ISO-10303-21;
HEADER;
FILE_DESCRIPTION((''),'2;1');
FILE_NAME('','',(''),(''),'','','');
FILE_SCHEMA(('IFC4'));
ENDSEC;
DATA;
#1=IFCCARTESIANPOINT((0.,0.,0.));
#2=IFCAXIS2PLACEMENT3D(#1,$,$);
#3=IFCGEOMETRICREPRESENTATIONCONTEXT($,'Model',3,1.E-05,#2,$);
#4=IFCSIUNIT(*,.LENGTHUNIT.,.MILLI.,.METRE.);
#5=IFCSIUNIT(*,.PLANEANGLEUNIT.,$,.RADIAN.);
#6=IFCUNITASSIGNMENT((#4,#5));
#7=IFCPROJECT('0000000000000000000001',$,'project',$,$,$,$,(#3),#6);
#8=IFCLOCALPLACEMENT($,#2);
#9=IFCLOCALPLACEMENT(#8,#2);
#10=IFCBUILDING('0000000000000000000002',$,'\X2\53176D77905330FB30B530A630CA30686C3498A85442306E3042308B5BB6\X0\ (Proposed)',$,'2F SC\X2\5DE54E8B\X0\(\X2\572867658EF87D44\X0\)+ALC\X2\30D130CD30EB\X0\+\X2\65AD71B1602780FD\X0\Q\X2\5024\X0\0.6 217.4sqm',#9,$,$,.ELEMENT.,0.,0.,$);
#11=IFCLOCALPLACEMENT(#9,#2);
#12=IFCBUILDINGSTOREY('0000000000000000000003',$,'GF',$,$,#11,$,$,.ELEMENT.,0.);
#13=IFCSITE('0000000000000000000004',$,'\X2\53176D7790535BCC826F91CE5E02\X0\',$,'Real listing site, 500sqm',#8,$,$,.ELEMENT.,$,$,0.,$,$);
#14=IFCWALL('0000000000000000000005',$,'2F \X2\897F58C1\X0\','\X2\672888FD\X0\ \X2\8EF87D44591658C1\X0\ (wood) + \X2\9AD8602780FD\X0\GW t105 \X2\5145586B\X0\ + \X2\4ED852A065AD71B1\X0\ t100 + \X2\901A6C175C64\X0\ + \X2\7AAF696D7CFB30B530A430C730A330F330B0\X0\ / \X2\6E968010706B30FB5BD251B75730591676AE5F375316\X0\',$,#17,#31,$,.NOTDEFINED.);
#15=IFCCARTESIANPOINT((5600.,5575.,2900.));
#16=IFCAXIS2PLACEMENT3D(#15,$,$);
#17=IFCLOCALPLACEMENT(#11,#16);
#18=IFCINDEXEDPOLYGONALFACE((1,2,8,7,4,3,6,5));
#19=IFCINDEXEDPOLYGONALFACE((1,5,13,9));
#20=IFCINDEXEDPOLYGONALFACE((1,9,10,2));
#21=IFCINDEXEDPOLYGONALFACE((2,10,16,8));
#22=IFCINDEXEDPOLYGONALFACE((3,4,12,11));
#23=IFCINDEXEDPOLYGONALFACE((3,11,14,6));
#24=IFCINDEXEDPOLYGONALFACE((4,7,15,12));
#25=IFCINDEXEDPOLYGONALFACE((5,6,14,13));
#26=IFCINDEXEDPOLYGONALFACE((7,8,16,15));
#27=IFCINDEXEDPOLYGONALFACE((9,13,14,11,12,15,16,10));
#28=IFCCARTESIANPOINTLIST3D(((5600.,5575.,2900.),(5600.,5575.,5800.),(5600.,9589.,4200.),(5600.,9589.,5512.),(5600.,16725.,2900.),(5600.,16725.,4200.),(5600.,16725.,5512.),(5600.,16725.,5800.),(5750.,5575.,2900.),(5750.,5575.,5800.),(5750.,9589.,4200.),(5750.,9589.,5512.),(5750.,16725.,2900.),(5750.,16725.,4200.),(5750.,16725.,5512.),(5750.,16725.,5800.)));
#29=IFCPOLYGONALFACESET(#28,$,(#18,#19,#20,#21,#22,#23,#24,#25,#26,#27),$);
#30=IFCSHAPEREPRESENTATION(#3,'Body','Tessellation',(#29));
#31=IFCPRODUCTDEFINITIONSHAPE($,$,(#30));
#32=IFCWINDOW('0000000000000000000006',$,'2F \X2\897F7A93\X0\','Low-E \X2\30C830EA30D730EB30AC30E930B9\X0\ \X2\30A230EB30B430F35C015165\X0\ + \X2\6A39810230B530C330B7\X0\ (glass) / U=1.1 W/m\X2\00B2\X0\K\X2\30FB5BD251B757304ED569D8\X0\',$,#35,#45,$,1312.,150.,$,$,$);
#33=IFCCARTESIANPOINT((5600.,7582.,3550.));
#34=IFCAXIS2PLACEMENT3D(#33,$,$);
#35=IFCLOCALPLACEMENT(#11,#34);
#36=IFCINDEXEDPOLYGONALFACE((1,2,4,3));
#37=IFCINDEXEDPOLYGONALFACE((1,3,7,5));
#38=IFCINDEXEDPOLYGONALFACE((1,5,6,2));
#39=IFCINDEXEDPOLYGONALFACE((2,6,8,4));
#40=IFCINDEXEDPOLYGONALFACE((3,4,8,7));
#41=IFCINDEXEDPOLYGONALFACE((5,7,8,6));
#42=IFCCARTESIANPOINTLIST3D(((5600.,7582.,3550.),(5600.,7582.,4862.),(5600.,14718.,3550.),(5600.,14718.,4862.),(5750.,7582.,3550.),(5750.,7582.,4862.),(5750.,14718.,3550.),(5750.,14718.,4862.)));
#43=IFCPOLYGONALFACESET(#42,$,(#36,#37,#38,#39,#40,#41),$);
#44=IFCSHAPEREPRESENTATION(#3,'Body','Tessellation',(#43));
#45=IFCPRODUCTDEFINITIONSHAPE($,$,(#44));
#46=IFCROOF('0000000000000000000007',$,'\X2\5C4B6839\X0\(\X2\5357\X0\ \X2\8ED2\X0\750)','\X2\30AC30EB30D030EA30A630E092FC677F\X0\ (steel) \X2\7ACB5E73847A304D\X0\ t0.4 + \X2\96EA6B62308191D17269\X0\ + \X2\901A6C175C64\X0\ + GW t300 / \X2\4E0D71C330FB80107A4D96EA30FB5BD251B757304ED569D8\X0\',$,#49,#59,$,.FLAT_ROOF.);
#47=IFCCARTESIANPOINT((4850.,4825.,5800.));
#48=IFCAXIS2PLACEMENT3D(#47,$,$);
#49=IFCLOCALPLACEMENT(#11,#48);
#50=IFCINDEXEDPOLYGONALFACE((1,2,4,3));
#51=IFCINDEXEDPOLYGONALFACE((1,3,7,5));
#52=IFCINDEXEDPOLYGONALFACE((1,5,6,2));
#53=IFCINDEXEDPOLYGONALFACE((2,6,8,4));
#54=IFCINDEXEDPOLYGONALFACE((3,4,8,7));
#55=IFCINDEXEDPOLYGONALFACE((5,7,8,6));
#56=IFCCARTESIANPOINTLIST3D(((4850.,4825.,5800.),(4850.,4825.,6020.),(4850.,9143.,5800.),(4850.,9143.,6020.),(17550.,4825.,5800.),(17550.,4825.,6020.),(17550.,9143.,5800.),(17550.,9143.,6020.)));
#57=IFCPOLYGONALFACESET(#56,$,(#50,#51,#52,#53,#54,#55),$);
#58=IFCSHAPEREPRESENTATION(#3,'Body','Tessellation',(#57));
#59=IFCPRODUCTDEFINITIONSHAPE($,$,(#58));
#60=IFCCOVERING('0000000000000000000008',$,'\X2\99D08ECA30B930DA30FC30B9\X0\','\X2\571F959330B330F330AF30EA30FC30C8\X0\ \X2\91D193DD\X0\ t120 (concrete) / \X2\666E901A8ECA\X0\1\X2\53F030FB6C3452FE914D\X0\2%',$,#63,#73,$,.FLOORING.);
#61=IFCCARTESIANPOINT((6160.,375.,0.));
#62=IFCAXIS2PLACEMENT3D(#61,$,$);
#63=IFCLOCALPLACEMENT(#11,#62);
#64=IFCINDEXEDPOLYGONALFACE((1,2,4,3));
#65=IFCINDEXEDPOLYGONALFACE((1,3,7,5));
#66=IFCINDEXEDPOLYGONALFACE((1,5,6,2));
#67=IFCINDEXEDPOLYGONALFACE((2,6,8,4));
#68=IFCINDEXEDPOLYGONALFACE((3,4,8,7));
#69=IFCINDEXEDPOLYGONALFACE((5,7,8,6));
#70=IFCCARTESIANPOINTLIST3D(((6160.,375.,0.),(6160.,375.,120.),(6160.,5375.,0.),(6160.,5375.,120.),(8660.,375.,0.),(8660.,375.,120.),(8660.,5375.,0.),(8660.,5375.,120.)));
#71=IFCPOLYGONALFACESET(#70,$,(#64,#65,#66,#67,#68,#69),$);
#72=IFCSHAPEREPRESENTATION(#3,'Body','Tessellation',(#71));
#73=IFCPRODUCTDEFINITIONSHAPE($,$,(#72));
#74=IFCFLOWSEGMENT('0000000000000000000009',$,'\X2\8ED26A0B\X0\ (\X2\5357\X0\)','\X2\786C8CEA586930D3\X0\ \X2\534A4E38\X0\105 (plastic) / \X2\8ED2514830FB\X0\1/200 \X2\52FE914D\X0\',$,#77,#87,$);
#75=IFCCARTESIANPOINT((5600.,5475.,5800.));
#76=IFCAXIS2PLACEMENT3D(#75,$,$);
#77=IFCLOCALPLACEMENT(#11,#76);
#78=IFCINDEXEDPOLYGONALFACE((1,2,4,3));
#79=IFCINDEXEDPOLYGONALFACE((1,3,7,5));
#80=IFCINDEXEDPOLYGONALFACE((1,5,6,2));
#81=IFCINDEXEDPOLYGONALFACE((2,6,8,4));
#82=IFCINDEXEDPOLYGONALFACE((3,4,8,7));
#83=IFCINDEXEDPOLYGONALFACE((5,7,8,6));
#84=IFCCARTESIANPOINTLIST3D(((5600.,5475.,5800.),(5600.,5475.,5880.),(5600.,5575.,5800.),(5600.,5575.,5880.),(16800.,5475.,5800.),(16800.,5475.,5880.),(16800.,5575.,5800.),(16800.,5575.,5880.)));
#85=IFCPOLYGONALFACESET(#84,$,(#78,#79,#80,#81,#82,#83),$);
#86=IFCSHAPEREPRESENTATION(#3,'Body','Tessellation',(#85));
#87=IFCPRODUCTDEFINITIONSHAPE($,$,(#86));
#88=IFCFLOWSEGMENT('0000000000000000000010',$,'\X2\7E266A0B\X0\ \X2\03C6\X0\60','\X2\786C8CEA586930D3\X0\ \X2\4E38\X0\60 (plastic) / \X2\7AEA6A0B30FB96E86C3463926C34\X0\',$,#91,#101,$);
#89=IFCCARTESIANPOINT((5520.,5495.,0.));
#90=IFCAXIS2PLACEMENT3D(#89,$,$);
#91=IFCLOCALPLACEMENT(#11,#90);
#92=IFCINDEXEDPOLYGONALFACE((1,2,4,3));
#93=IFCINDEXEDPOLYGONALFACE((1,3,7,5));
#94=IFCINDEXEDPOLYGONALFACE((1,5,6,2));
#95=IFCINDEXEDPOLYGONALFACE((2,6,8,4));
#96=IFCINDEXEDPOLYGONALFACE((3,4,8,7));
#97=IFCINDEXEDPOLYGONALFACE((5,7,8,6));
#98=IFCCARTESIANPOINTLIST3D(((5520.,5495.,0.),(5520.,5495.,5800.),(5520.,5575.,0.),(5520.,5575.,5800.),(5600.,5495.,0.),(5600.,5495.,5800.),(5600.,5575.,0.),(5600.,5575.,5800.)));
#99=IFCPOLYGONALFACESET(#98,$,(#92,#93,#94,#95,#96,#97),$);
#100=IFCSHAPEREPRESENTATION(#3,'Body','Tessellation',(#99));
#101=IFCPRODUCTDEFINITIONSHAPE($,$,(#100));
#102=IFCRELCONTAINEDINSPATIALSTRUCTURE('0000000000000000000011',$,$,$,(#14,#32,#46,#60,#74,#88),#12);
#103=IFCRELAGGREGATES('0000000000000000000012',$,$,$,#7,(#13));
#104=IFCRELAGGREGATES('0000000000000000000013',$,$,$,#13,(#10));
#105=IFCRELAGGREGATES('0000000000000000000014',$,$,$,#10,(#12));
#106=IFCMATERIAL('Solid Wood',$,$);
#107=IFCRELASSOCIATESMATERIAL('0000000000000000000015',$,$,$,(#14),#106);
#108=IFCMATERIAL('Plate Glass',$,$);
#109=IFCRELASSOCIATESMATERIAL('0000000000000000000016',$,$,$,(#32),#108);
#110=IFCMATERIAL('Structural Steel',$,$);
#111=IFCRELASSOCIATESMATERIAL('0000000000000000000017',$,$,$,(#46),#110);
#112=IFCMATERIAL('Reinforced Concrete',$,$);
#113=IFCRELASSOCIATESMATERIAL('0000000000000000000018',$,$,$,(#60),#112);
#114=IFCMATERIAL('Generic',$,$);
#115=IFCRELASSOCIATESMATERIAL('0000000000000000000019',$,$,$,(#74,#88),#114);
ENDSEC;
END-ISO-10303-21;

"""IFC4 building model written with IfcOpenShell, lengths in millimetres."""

from ifc_helpers import new_model, si_unit, frame, frame_2d, origin, place, context, project, spatial, rectangle, extrude, material, element, fill, save


model = new_model("IFC4")

# Units and contexts
model_context = context("Model", 3, precision=1e-05, world=origin())
ifc_project = project(units=[si_unit("LENGTHUNIT", "METRE", prefix="MILLI"), si_unit("PLANEANGLEUNIT", "RADIAN")], contexts=[model_context])

# Site, building, storey
site_placement = place(None, origin())
site = spatial("IfcSite", under=ifc_project, at=site_placement, Name="北海道富良野市", ObjectType="Real listing site, 500sqm", CompositionType="ELEMENT", RefElevation=0.0)
building_placement = place(site_placement, origin())
building = spatial("IfcBuilding", under=site, at=building_placement, Name="北海道・サウナと水風呂のある家 (Proposed)", ObjectType="2F SC工事(在来軸組)+ALCパネル+断熱性能Q値0.6 217.4sqm", CompositionType="ELEMENT", ElevationOfRefHeight=0.0, ElevationOfTerrain=0.0)
storey_placement = place(building_placement, origin())
storey = spatial("IfcBuildingStorey", under=building, at=storey_placement, Name="GF", CompositionType="ELEMENT", Elevation=0.0)

# Shared definitions
ifc_material_1 = material(Name="Solid Wood")

# Shared definitions
ifc_material_2 = material(Name="Reinforced Concrete")

# Shared definitions
ifc_material_3 = material(Name="Plate Glass")

# Wall, opening, window
wall_1_placement = place(storey_placement, frame((5600.0, 5575.0, 2900.0)))
wall_1 = element("IfcWall", 1, at=wall_1_placement, inside=storey, material=ifc_material_1, Name="2F 西壁", Description="木製 軸組外壁 (wood) + 高性能GW t105 充填 + 付加断熱 t100 + 通気層 + 窯業系サイディング / 準耐火・寒冷地外皮強化", PredefinedType="NOTDEFINED", context=model_context, shape_type="SweptSolid", body=[
    extrude(rectangle(XDim=150.0, YDim=11150.0, at=frame_2d((75.0, 5575.0))), frame((5600.0, 5575.0, 2900.0)), (0.0, 0.0, 1.0), 2900.0),
])
opening_1_placement = place(storey_placement, frame((5600.0, 7582.0, 3550.0)))
opening_1 = element("IfcOpeningElement", 2, at=opening_1_placement, cuts=wall_1, PredefinedType="NOTDEFINED", context=model_context, shape_type="SweptSolid", body=[
    extrude(rectangle(XDim=150.0, YDim=7136.0, at=frame_2d((75.0, 3568.0))), frame((5600.0, 7582.0, 3550.0)), (0.0, 0.0, 1.0), 1312.0),
])
window_1_placement = place(storey_placement, frame((5600.0, 7582.0, 3550.0)))
window_1 = element("IfcWindow", 3, at=window_1_placement, inside=storey, material=ifc_material_3, Name="2F 西窓", Description="Low-E トリプルガラス アルゴン封入 + 樹脂サッシ (glass) / U=1.1 W/m²K・寒冷地仕様", OverallHeight=1312.0, OverallWidth=150.0, context=model_context, shape_type="SweptSolid", body=[
    extrude(rectangle(XDim=150.0, YDim=7136.0, at=frame_2d((75.0, 3568.0))), frame((5600.0, 7582.0, 3550.0)), (0.0, 0.0, 1.0), 1312.0),
])
fill(opening_1, window_1)

# Roof
ifc_material_4 = material(Name="Structural Steel")
for number, where, name in (
    (4, (4850.0, 4825.0, 5800.0), "屋根(南 軒750)"),
):
    element("IfcRoof", number, at=place(storey_placement, frame(where)), inside=storey, material=ifc_material_4, Name=name, Description="ガルバリウム鋼板 (steel) 立平葺き t0.4 + 雪止め金物 + 通気層 + GW t300 / 不燃・耐積雪・寒冷地仕様", PredefinedType="FLAT_ROOF", context=model_context, shape_type="SweptSolid", body=[
        extrude(rectangle(XDim=12700.0, YDim=4318.0, at=frame_2d((6350.0, 2159.0))), frame((4850.0, 4825.0, 5800.0)), (0.0, 0.0, 1.0), 220.0),
    ])

# Covering
covering_placement = place(storey_placement, frame((6160.0, 375.0, 0.0)))
element("IfcCovering", 5, at=covering_placement, inside=storey, material=ifc_material_2, Name="駐車スペース", Description="土間コンクリート 金鏝 t120 (concrete) / 普通車1台・水勾配2%", PredefinedType="FLOORING", context=model_context, shape_type="SweptSolid", body=[
    extrude(rectangle(XDim=2500.0, YDim=5000.0, at=frame_2d((1250.0, 2500.0))), frame((6160.0, 375.0, 0.0)), (0.0, 0.0, 1.0), 120.0),
])

# Flow segments
ifc_material_5 = material(Name="Generic")
flow_segment_1_placement = place(storey_placement, frame((5600.0, 5475.0, 5800.0)))
element("IfcFlowSegment", 6, at=flow_segment_1_placement, inside=storey, material=ifc_material_5, Name="軒樋 (南)", Description="硬質塩ビ 半丸105 (plastic) / 軒先・1/200 勾配", context=model_context, shape_type="SweptSolid", body=[
    extrude(rectangle(XDim=11200.0, YDim=100.0, at=frame_2d((5600.0, 50.0))), frame((5600.0, 5475.0, 5800.0)), (0.0, 0.0, 1.0), 80.0),
])
flow_segment_2_placement = place(storey_placement, frame((5520.0, 5495.0, 0.0)))
element("IfcFlowSegment", 7, at=flow_segment_2_placement, inside=storey, material=ifc_material_5, Name="縦樋 φ60", Description="硬質塩ビ 丸60 (plastic) / 竪樋・雨水排水", context=model_context, shape_type="SweptSolid", body=[
    extrude(rectangle(XDim=80.0, YDim=80.0, at=frame_2d((40.0, 40.0))), frame((5520.0, 5495.0, 0.0)), (0.0, 0.0, 1.0), 5800.0),
])

save(model, "model.ifc")
